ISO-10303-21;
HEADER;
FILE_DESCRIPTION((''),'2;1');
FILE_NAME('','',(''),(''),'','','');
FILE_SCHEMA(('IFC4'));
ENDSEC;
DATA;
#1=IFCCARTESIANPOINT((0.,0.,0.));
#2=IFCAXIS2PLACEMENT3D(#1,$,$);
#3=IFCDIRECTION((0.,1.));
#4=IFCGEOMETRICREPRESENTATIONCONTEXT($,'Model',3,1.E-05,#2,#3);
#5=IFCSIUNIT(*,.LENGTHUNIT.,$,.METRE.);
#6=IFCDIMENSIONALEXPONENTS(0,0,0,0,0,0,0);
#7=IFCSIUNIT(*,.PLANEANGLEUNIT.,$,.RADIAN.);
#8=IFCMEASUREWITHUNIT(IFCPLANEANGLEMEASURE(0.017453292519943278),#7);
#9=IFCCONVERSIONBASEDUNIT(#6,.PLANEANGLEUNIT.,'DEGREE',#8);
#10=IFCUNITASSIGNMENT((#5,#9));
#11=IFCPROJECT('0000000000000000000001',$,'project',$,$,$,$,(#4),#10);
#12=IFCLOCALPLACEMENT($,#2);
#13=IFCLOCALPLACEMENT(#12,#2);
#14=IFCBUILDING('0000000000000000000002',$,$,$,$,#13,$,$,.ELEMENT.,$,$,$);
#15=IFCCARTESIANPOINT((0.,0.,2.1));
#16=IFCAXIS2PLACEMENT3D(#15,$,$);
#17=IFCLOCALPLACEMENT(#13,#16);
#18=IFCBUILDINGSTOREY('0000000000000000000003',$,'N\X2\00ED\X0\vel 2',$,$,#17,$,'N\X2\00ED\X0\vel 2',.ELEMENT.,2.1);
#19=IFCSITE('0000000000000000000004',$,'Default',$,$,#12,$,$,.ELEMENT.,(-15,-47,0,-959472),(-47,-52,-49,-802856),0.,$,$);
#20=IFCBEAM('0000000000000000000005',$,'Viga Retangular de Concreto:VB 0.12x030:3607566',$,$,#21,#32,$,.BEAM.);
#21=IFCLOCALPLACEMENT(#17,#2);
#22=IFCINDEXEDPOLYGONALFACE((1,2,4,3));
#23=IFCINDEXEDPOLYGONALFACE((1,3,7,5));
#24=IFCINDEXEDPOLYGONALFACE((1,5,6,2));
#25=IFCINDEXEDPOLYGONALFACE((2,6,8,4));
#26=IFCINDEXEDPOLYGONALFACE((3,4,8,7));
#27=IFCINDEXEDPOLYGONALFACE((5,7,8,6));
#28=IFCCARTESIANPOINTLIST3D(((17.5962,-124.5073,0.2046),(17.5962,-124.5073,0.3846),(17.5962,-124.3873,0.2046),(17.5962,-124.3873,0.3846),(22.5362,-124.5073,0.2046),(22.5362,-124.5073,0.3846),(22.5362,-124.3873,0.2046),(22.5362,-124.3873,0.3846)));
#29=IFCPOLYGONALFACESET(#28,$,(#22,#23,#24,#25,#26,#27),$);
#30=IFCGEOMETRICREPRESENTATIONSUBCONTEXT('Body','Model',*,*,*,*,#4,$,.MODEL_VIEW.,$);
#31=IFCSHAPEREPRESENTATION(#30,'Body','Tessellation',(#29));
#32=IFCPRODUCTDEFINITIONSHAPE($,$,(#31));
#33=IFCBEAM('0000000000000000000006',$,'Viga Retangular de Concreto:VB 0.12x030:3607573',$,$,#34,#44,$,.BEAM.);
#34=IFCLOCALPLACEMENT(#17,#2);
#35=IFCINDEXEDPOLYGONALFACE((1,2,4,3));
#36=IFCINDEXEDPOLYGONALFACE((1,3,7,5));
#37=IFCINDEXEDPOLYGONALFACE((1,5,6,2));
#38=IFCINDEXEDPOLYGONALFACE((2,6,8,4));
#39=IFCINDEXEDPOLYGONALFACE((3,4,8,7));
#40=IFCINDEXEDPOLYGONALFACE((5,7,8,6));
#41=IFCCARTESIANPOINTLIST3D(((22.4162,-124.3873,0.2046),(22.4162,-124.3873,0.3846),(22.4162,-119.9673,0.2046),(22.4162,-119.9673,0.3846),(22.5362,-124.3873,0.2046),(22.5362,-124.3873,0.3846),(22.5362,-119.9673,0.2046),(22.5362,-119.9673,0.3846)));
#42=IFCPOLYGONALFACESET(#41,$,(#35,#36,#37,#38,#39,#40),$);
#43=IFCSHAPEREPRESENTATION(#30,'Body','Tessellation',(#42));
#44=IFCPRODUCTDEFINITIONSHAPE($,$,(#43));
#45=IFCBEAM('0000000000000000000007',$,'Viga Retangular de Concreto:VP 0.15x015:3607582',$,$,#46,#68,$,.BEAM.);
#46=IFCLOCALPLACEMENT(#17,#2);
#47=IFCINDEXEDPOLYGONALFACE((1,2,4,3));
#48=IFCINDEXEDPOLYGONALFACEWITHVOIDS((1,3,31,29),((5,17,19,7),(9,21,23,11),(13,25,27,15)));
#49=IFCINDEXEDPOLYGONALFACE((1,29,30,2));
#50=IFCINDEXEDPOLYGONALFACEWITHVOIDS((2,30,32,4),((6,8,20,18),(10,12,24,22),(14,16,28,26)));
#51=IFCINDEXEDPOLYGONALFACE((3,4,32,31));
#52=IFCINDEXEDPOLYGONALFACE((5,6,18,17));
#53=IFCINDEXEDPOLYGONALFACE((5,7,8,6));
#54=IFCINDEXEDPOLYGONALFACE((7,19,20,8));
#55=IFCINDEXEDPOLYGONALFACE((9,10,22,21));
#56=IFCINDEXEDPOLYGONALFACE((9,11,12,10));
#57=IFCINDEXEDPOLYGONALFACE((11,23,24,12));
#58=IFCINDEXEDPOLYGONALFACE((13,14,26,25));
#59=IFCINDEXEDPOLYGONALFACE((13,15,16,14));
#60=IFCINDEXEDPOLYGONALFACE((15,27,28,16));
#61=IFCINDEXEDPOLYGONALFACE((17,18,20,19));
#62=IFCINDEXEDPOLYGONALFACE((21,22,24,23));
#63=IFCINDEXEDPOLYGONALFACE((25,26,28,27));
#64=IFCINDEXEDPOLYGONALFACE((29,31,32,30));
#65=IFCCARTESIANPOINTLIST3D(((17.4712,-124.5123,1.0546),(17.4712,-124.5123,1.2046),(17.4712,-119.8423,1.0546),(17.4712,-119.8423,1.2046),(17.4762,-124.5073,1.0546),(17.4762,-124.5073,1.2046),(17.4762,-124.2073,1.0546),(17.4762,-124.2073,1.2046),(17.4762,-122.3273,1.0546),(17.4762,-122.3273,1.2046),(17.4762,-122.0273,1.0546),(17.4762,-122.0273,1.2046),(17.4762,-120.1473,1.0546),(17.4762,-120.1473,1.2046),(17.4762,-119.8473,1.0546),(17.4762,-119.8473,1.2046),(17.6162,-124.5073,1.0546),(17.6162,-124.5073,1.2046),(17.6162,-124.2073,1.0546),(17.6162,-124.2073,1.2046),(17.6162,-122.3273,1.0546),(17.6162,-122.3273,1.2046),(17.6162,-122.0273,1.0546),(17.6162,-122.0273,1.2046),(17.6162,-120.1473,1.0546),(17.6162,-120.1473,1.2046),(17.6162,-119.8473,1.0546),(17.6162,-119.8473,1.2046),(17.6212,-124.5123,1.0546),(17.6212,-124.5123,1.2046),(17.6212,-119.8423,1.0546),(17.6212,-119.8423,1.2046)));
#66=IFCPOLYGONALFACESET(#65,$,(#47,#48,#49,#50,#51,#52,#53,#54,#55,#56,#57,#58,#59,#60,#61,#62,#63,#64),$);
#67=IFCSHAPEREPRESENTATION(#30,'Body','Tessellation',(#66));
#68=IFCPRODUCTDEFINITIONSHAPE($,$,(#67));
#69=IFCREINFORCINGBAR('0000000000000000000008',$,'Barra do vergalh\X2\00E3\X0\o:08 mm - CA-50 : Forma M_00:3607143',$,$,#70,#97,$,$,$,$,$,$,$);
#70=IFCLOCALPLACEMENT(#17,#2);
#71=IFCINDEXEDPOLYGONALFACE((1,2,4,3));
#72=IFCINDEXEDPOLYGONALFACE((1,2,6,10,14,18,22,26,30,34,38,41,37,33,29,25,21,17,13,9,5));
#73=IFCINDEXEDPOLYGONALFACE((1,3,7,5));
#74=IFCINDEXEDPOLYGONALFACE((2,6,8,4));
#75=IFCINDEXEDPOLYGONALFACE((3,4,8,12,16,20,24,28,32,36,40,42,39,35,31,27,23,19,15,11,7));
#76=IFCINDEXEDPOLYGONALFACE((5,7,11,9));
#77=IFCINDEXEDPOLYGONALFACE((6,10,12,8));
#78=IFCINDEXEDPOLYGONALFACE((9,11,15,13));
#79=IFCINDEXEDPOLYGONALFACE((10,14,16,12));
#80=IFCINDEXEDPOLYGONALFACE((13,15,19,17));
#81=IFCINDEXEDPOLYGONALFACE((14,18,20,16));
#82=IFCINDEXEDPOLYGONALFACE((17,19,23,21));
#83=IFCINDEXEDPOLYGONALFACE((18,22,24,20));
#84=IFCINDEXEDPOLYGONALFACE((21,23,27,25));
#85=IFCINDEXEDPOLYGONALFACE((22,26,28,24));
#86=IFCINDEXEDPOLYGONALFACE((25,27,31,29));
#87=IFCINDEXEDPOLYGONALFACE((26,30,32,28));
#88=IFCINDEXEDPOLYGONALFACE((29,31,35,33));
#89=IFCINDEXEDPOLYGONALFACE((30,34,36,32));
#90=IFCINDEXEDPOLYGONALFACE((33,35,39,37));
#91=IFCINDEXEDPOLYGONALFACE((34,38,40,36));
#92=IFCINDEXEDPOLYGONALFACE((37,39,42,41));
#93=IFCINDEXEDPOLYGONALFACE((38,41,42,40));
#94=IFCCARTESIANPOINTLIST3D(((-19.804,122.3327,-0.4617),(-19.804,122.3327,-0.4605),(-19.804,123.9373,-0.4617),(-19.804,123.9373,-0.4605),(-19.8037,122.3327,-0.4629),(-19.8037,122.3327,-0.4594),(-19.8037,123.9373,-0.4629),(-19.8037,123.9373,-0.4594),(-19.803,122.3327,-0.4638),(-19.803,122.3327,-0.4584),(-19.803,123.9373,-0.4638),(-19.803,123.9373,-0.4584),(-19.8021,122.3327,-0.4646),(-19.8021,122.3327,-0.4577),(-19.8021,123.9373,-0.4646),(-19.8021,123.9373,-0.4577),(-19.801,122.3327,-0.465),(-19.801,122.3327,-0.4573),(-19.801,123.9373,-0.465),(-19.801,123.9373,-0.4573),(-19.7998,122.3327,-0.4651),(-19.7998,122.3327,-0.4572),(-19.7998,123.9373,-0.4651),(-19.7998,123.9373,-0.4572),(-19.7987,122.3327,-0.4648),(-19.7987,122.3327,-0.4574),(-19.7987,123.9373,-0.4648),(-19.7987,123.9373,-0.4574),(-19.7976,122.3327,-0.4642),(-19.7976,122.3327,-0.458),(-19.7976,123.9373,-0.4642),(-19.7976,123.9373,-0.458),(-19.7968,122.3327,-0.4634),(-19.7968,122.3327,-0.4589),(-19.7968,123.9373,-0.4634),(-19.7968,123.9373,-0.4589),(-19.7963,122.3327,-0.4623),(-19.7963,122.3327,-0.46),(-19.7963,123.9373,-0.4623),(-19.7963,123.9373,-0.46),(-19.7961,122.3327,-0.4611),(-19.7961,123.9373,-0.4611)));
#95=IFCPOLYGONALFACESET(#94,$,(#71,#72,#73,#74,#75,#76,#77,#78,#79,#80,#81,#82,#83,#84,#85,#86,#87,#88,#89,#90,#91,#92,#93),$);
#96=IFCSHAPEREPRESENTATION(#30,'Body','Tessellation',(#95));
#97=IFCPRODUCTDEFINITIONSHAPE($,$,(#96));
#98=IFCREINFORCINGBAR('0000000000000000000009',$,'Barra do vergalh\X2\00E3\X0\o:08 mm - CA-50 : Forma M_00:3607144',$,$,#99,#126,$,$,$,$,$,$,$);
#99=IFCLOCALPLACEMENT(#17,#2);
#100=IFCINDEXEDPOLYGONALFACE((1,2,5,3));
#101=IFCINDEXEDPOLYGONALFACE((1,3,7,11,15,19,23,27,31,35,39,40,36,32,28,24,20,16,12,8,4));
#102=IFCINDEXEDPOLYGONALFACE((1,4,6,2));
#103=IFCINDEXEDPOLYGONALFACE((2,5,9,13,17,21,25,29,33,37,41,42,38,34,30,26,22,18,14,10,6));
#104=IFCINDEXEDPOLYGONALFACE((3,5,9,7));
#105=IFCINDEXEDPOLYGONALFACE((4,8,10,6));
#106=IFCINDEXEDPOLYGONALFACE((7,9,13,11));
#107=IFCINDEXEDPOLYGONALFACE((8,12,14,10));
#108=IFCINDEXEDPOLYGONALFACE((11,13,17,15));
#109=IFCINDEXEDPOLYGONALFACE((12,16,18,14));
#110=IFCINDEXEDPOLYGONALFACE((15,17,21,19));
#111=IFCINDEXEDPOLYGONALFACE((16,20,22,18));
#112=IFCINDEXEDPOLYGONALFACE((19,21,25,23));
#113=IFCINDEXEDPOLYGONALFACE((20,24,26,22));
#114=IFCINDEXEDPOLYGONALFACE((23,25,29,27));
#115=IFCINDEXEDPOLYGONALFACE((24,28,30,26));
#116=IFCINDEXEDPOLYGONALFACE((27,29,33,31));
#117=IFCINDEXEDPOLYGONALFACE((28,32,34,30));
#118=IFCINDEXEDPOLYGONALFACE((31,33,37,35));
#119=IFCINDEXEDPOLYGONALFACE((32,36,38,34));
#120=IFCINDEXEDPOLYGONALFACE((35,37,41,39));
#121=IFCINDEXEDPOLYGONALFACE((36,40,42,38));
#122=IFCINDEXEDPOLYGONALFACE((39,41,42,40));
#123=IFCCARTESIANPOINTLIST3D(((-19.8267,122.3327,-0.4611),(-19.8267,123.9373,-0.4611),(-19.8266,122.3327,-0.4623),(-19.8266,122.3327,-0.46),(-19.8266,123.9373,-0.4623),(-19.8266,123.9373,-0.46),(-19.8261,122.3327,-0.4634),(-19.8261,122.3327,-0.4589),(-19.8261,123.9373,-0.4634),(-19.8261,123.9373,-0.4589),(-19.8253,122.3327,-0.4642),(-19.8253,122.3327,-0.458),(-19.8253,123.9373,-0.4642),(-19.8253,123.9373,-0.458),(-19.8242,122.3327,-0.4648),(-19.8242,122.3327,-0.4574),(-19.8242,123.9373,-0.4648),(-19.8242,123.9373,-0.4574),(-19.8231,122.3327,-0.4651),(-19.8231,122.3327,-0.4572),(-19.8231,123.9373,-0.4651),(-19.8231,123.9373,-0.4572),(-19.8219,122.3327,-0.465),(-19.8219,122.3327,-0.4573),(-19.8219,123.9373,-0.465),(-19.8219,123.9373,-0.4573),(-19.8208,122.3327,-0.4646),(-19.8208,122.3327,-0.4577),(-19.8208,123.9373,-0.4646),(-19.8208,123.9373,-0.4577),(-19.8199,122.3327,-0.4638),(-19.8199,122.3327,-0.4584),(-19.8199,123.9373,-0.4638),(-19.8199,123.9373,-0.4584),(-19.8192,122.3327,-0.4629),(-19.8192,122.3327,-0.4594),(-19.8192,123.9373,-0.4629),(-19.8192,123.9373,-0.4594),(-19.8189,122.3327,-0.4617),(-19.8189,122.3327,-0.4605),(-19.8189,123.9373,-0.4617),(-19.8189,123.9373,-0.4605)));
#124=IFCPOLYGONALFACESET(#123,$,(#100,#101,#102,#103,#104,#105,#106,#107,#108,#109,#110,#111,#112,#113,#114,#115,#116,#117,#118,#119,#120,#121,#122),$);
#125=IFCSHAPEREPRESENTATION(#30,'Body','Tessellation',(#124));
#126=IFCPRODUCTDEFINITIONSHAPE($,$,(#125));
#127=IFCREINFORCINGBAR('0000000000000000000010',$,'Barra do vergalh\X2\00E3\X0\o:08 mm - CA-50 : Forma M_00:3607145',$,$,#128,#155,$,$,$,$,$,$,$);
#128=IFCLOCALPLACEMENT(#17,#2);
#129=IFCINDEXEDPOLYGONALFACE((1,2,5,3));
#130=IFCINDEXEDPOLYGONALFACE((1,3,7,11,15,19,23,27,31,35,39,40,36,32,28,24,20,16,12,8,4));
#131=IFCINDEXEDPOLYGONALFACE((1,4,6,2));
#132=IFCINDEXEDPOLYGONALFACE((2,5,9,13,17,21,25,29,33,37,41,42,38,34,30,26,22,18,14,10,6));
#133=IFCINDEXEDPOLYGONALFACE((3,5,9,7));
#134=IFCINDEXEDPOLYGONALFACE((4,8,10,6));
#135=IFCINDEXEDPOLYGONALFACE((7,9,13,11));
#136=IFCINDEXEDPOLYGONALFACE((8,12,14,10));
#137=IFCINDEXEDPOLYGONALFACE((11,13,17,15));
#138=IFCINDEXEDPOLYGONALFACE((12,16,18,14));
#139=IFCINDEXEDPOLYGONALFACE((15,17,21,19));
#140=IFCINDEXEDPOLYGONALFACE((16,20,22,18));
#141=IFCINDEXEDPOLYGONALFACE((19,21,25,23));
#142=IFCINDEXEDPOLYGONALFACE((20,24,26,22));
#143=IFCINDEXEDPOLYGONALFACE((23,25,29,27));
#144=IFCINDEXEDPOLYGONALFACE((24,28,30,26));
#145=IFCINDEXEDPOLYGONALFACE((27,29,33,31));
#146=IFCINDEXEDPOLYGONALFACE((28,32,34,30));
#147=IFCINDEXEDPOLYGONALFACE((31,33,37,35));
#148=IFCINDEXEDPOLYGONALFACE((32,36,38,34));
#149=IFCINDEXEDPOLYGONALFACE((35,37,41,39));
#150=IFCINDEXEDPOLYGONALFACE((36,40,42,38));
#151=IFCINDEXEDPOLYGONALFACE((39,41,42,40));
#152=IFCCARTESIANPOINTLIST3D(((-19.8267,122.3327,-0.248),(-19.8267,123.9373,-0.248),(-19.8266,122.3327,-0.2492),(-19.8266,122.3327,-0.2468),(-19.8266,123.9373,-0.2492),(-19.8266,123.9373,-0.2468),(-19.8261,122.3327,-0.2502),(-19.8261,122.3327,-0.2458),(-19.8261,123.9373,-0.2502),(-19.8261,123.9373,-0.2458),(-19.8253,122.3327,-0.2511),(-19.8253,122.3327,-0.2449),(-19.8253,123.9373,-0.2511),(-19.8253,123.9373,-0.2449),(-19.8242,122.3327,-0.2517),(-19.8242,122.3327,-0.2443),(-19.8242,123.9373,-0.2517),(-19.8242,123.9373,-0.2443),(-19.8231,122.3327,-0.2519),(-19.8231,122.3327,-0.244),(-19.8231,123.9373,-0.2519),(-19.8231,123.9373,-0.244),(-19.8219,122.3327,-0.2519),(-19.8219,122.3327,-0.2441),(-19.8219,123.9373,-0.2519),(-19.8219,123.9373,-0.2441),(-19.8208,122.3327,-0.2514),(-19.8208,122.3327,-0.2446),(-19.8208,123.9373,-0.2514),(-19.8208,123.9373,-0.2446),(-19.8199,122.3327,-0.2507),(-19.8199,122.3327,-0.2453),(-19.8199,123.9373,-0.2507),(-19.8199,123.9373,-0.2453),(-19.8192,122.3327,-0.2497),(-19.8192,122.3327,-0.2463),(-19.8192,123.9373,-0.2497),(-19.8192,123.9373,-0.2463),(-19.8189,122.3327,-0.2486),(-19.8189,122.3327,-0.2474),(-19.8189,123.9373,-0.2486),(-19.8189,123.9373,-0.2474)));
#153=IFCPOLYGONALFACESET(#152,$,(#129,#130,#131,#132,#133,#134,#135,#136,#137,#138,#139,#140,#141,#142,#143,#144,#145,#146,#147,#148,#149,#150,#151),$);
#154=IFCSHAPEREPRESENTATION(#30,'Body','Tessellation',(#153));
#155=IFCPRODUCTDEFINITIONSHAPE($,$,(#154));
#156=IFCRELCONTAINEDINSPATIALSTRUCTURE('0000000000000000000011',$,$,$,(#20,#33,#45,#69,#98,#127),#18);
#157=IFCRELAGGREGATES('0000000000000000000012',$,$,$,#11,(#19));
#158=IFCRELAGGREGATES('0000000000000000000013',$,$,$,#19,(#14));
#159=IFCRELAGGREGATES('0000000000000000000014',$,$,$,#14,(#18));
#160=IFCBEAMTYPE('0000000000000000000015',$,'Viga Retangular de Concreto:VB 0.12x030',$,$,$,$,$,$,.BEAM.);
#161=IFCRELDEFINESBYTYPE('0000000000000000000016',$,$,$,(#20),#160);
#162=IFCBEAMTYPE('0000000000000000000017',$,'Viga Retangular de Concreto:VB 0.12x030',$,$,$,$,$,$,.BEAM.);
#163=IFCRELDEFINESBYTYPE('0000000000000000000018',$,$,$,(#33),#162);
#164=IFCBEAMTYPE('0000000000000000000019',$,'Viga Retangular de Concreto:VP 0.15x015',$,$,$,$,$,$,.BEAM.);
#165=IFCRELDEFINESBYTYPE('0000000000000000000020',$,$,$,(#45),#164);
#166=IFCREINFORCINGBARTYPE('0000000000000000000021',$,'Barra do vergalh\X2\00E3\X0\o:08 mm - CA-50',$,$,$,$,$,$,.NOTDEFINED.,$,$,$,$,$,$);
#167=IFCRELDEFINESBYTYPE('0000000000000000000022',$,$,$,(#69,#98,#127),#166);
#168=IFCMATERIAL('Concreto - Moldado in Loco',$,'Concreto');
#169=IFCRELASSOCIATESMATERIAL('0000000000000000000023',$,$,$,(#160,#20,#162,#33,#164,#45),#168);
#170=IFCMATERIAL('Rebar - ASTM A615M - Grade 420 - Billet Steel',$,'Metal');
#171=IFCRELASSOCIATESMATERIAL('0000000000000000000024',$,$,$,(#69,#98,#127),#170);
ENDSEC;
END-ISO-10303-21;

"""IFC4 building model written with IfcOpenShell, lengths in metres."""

from ifc_helpers import new_model, entity, si_unit, converted_unit, direction, frame, origin, place, context, subcontext, project, spatial, indexed_curve, outline, extrude, source, transform, mapped, material, type_object, type_shapes, element, save


model = new_model("IFC4")

# Units and contexts
model_context = context("Model", 3, precision=1e-05, world=origin(), true_north=direction((0.0, 1.0)))
body_context = subcontext(model_context, "Body", "Model", "MODEL_VIEW")
ifc_project = project(units=[si_unit("LENGTHUNIT", "METRE"), converted_unit("PLANEANGLEUNIT", "DEGREE", entity("IfcPlaneAngleMeasure", 0.017453292519943278), si_unit("PLANEANGLEUNIT", "RADIAN"), dimensions=[0, 0, 0, 0, 0, 0, 0])], contexts=[model_context])

# Site, building, storey
site_placement = place(None, origin())
site = spatial("IfcSite", under=ifc_project, at=site_placement, Name="Default", CompositionType="ELEMENT", RefLatitude=(-15, -47, 0, -959472), RefLongitude=(-47, -52, -49, -802856), RefElevation=0.0)
building_placement = place(site_placement, origin())
building = spatial("IfcBuilding", under=site, at=building_placement, CompositionType="ELEMENT")
storey_placement = place(building_placement, frame((0.0, 0.0, 2.1)))
storey = spatial("IfcBuildingStorey", under=building, at=storey_placement, Name="Nível 2", LongName="Nível 2", CompositionType="ELEMENT", Elevation=2.1)

# Shared definitions
ifc_material_1 = material(Name="Concreto - Moldado in Loco", Category="Concreto")

# Beams
beam_type_1 = type_object("IfcBeamType", Name="Viga Retangular de Concreto:VB 0.12x030", PredefinedType="BEAM", material=ifc_material_1)
shared_shape_1 = source(origin(), body_context, "Body", "SweptSolid", [
    extrude(outline(indexed_curve([(-0.09, -0.06), (0.09, -0.06), (0.09, 0.06), (-0.09, 0.06), (-0.09, -0.06)], self_intersect=False)), frame((17.5962, -124.4473, 2.3946), z_axis=(1.0, 0.0, 0.0), x_axis=(0.0, 0.0, -1.0)), (0.0, 0.0, 1.0), 4.94),
])
type_shapes(beam_type_1, [shared_shape_1])
beam_1_placement = place(storey_placement, frame((0.0, 0.0, -2.1)))
element("IfcBeam", 1, at=beam_1_placement, inside=storey, type_object=beam_type_1, material=ifc_material_1, Name="Viga Retangular de Concreto:VB 0.12x030:3607566", PredefinedType="BEAM", context=body_context, shape_type="MappedRepresentation", body=[
    mapped(shared_shape_1, transform((0.0, 0.0, 0.0), scale=1.0)),
])
beam_type_2 = type_object("IfcBeamType", Name="Viga Retangular de Concreto:VB 0.12x030", PredefinedType="BEAM", material=ifc_material_1)
shared_shape_2 = source(origin(), body_context, "Body", "SweptSolid", [
    extrude(outline(indexed_curve([(-0.06, -0.09), (0.06, -0.09), (0.06, 0.09), (-0.06, 0.09), (-0.06, -0.09)], self_intersect=False)), frame((22.4762, -124.3873, 2.3946), z_axis=(0.0, 1.0, 0.0), x_axis=(-1.0, 0.0, 0.0)), (0.0, 0.0, 1.0), 4.42),
])
type_shapes(beam_type_2, [shared_shape_2])
beam_2_placement = place(storey_placement, frame((0.0, 0.0, -2.1)))
element("IfcBeam", 2, at=beam_2_placement, inside=storey, type_object=beam_type_2, material=ifc_material_1, Name="Viga Retangular de Concreto:VB 0.12x030:3607573", PredefinedType="BEAM", context=body_context, shape_type="MappedRepresentation", body=[
    mapped(shared_shape_2, transform((0.0, 0.0, 0.0), scale=1.0)),
])

# Beam, openings
beam_type_3 = type_object("IfcBeamType", Name="Viga Retangular de Concreto:VP 0.15x015", PredefinedType="BEAM", material=ifc_material_1)
shared_shape_3 = source(origin(), body_context, "Body", "SweptSolid", [
    extrude(outline(indexed_curve([(-2.335, -0.075), (2.335, -0.075), (2.335, 0.075), (-2.335, 0.075), (-2.335, -0.075)], self_intersect=False)), frame((17.4712, -122.1773, 3.2296), z_axis=(1.0, 0.0, 0.0), x_axis=(0.0, 1.0, 0.0)), (0.0, 0.0, 1.0), 0.15),
])
type_shapes(beam_type_3, [shared_shape_3])
beam_3_placement = place(storey_placement, frame((0.0, 0.0, -2.1)))
beam_3 = element("IfcBeam", 3, at=beam_3_placement, inside=storey, type_object=beam_type_3, material=ifc_material_1, Name="Viga Retangular de Concreto:VP 0.15x015:3607582", PredefinedType="BEAM", context=body_context, shape_type="MappedRepresentation", body=[
    mapped(shared_shape_3, transform((0.0, 0.0, 0.0), scale=1.0)),
])
opening_1_placement = place(storey_placement, frame((0.0, 0.0, -2.1)))
element("IfcOpeningElement", 4, at=opening_1_placement, cuts=beam_3, PredefinedType="OPENING", context=body_context, shape_type="SweptSolid", body=[
    extrude(outline(indexed_curve([(-0.07, -0.15), (0.07, -0.15), (0.07, 0.15), (-0.07, 0.15), (-0.07, -0.15)], self_intersect=False)), frame((17.5462, -122.1773, 3.1546)), (0.0, 0.0, 1.0), 0.15),
])
opening_2_placement = place(storey_placement, frame((0.0, 0.0, -2.1)))
element("IfcOpeningElement", 5, at=opening_2_placement, cuts=beam_3, PredefinedType="OPENING", context=body_context, shape_type="SweptSolid", body=[
    extrude(outline(indexed_curve([(-0.07, -0.15), (0.07, -0.15), (0.07, 0.15), (-0.07, 0.15), (-0.07, -0.15)], self_intersect=False)), frame((17.5462, -119.9973, 3.1546)), (0.0, 0.0, 1.0), 0.15),
])
opening_3_placement = place(storey_placement, frame((0.0, 0.0, -2.1)))
element("IfcOpeningElement", 6, at=opening_3_placement, cuts=beam_3, PredefinedType="OPENING", context=body_context, shape_type="SweptSolid", body=[
    extrude(outline(indexed_curve([(-0.07, -0.15), (0.07, -0.15), (0.07, 0.15), (-0.07, 0.15), (-0.07, -0.15)], self_intersect=False)), frame((17.5462, -124.3573, 3.1546), z_axis=(0.0, 0.0, 1.0), x_axis=(-1.0, 0.0, 0.0)), (0.0, 0.0, 1.0), 0.15),
])

# Reinforcing bars
ifc_material_2 = material(Name="Rebar - ASTM A615M - Grade 420 - Billet Steel", Category="Metal")
reinforcing_bar_type_1 = type_object("IfcReinforcingBarType", Name="Barra do vergalhão:08 mm - CA-50", PredefinedType="NOTDEFINED")
reinforcing_bar_1_placement = place(storey_placement, origin())
element("IfcReinforcingBar", 7, at=reinforcing_bar_1_placement, inside=storey, type_object=reinforcing_bar_type_1, material=ifc_material_2, Name="Barra do vergalhão:08 mm - CA-50 : Forma M_00:3607143", context=body_context, shape_type="AdvancedSweptSolid", body=[
    entity("IfcSweptDiskSolid", entity("IfcIndexedPolyCurve", entity("IfcCartesianPointList3D", [[19.8001, -123.9373, 0.4611], [19.8001, -122.3327, 0.4611]]), None, False), 0.004, None, 0.0, 1.0),
])
reinforcing_bar_2_placement = place(storey_placement, origin())
element("IfcReinforcingBar", 8, at=reinforcing_bar_2_placement, inside=storey, type_object=reinforcing_bar_type_1, material=ifc_material_2, Name="Barra do vergalhão:08 mm - CA-50 : Forma M_00:3607144", context=body_context, shape_type="AdvancedSweptSolid", body=[
    entity("IfcSweptDiskSolid", entity("IfcIndexedPolyCurve", entity("IfcCartesianPointList3D", [[19.8228, -122.3327, 0.4611], [19.8228, -123.9373, 0.4611]]), None, False), 0.004, None, 0.0, 1.0),
])
reinforcing_bar_3_placement = place(storey_placement, origin())
element("IfcReinforcingBar", 9, at=reinforcing_bar_3_placement, inside=storey, type_object=reinforcing_bar_type_1, material=ifc_material_2, Name="Barra do vergalhão:08 mm - CA-50 : Forma M_00:3607145", context=body_context, shape_type="AdvancedSweptSolid", body=[
    entity("IfcSweptDiskSolid", entity("IfcIndexedPolyCurve", entity("IfcCartesianPointList3D", [[19.8228, -122.3327, 0.248], [19.8228, -123.9373, 0.248]]), None, False), 0.004, None, 0.0, 1.0),
])

save(model, "model.ifc")
